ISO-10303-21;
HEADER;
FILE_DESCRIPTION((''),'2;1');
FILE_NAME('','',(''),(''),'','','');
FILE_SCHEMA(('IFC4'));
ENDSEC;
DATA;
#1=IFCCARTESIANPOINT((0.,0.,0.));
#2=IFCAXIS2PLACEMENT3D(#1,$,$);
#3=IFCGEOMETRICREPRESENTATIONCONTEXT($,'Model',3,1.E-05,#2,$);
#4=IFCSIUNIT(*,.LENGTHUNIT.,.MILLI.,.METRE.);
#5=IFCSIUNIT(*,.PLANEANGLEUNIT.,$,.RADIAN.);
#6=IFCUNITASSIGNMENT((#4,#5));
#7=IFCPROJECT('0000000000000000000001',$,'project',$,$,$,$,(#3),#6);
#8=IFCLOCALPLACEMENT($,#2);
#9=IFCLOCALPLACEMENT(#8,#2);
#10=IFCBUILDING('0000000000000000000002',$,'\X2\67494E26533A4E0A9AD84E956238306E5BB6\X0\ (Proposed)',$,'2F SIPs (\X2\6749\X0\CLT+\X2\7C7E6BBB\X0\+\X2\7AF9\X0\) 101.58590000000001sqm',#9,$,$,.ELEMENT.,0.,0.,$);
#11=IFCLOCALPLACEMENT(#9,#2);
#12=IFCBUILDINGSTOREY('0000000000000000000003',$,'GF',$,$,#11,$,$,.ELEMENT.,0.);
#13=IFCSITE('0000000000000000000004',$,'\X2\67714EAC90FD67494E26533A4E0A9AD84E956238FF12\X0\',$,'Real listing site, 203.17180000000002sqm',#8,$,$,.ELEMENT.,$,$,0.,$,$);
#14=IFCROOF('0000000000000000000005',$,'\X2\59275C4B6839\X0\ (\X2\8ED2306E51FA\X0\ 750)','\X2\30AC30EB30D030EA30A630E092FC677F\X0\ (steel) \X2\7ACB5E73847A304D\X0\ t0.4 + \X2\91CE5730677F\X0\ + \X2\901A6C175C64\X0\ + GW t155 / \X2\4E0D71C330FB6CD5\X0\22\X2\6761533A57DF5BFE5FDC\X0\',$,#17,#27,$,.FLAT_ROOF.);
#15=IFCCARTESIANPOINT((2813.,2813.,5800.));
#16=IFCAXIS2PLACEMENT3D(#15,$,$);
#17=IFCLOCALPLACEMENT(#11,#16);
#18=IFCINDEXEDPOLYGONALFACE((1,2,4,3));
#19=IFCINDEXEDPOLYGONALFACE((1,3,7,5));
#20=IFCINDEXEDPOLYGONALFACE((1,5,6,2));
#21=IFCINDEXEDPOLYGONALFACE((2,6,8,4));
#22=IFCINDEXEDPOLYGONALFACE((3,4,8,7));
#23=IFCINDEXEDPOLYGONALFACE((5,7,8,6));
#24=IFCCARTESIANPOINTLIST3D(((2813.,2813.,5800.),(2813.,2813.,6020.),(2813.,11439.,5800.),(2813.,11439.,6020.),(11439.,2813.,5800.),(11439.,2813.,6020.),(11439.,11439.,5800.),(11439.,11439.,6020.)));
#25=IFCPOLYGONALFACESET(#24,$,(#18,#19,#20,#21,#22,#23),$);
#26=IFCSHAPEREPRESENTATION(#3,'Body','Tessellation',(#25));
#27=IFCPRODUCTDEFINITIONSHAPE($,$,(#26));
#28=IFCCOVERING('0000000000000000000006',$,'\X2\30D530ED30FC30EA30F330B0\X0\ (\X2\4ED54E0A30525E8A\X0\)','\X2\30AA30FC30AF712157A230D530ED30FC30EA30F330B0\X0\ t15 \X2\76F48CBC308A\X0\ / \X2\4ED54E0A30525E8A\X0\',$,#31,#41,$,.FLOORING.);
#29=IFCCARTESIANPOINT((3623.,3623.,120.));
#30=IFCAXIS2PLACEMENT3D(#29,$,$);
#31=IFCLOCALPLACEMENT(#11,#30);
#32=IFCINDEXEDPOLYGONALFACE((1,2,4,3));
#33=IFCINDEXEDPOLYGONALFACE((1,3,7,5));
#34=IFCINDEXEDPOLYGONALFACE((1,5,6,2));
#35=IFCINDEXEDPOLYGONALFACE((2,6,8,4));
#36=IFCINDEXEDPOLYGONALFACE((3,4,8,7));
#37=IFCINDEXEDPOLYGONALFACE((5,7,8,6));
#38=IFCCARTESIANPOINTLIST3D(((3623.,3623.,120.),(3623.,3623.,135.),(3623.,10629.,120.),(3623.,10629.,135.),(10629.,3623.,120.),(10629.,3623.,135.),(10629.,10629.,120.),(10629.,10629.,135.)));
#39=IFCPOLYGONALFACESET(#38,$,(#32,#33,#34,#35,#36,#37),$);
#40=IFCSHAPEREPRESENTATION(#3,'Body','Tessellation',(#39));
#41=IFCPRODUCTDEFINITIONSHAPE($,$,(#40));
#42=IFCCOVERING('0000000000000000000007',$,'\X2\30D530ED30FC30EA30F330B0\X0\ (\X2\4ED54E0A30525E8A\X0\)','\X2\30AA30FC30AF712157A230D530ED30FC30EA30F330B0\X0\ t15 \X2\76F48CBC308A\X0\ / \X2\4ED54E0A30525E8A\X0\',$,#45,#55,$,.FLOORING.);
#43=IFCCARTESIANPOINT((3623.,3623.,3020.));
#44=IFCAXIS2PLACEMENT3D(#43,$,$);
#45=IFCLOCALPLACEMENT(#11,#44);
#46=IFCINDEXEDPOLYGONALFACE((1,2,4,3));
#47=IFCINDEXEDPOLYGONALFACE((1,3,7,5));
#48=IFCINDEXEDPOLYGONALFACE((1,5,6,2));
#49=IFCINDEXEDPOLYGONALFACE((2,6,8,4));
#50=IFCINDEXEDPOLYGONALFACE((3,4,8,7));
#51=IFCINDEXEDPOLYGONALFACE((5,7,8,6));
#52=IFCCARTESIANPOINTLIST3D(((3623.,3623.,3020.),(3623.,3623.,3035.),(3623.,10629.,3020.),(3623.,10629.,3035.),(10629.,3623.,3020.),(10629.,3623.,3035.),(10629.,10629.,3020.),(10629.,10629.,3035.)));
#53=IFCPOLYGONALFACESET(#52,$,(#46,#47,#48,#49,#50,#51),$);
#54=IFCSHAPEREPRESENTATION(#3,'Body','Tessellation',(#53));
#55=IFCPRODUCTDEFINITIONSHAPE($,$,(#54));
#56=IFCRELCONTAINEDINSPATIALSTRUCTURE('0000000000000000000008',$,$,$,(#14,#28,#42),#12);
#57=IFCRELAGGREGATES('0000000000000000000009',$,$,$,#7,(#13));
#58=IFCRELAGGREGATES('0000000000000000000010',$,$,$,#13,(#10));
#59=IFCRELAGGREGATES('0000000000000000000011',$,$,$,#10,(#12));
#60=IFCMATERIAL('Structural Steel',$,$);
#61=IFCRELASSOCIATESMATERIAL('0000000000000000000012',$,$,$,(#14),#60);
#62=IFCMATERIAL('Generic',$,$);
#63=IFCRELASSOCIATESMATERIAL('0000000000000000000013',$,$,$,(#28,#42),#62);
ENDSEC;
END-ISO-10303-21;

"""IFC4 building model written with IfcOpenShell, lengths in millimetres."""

from ifc_helpers import new_model, si_unit, frame, frame_2d, origin, place, context, project, spatial, rectangle, extrude, material, element, save


model = new_model("IFC4")

# Units and contexts
model_context = context("Model", 3, precision=1e-05, world=origin())
ifc_project = project(units=[si_unit("LENGTHUNIT", "METRE", prefix="MILLI"), si_unit("PLANEANGLEUNIT", "RADIAN")], contexts=[model_context])

# Site, building, storey
site_placement = place(None, origin())
site = spatial("IfcSite", under=ifc_project, at=site_placement, Name="東京都杉並区上高井戸２", ObjectType="Real listing site, 203.17180000000002sqm", CompositionType="ELEMENT", RefElevation=0.0)
building_placement = place(site_placement, origin())
building = spatial("IfcBuilding", under=site, at=building_placement, Name="杉並区上高井戸の家 (Proposed)", ObjectType="2F SIPs (杉CLT+籾殻+竹) 101.58590000000001sqm", CompositionType="ELEMENT", ElevationOfRefHeight=0.0, ElevationOfTerrain=0.0)
storey_placement = place(building_placement, origin())
storey = spatial("IfcBuildingStorey", under=building, at=storey_placement, Name="GF", CompositionType="ELEMENT", Elevation=0.0)

# Roof
ifc_material_1 = material(Name="Structural Steel")
roof_placement = place(storey_placement, frame((2813.0, 2813.0, 5800.0)))
element("IfcRoof", 1, at=roof_placement, inside=storey, material=ifc_material_1, Name="大屋根 (軒の出 750)", Description="ガルバリウム鋼板 (steel) 立平葺き t0.4 + 野地板 + 通気層 + GW t155 / 不燃・法22条区域対応", PredefinedType="FLAT_ROOF", context=model_context, shape_type="SweptSolid", body=[
    extrude(rectangle(XDim=8626.0, YDim=8626.0, at=frame_2d((4313.0, 4313.0))), frame((2813.0, 2813.0, 5800.0)), (0.0, 0.0, 1.0), 220.0),
])

# Coverings
ifc_material_2 = material(Name="Generic")
covering_1_placement = place(storey_placement, frame((3623.0, 3623.0, 120.0)))
element("IfcCovering", 2, at=covering_1_placement, inside=storey, material=ifc_material_2, Name="フローリング (仕上げ床)", Description="オーク無垢フローリング t15 直貼り / 仕上げ床", PredefinedType="FLOORING", context=model_context, shape_type="SweptSolid", body=[
    extrude(rectangle(XDim=7006.0, YDim=7006.0, at=frame_2d((3503.0, 3503.0))), frame((3623.0, 3623.0, 120.0)), (0.0, 0.0, 1.0), 15.0),
])
covering_2_placement = place(storey_placement, frame((3623.0, 3623.0, 3020.0)))
element("IfcCovering", 3, at=covering_2_placement, inside=storey, material=ifc_material_2, Name="フローリング (仕上げ床)", Description="オーク無垢フローリング t15 直貼り / 仕上げ床", PredefinedType="FLOORING", context=model_context, shape_type="SweptSolid", body=[
    extrude(rectangle(XDim=7006.0, YDim=7006.0, at=frame_2d((3503.0, 3503.0))), frame((3623.0, 3623.0, 3020.0)), (0.0, 0.0, 1.0), 15.0),
])

save(model, "model.ifc")
